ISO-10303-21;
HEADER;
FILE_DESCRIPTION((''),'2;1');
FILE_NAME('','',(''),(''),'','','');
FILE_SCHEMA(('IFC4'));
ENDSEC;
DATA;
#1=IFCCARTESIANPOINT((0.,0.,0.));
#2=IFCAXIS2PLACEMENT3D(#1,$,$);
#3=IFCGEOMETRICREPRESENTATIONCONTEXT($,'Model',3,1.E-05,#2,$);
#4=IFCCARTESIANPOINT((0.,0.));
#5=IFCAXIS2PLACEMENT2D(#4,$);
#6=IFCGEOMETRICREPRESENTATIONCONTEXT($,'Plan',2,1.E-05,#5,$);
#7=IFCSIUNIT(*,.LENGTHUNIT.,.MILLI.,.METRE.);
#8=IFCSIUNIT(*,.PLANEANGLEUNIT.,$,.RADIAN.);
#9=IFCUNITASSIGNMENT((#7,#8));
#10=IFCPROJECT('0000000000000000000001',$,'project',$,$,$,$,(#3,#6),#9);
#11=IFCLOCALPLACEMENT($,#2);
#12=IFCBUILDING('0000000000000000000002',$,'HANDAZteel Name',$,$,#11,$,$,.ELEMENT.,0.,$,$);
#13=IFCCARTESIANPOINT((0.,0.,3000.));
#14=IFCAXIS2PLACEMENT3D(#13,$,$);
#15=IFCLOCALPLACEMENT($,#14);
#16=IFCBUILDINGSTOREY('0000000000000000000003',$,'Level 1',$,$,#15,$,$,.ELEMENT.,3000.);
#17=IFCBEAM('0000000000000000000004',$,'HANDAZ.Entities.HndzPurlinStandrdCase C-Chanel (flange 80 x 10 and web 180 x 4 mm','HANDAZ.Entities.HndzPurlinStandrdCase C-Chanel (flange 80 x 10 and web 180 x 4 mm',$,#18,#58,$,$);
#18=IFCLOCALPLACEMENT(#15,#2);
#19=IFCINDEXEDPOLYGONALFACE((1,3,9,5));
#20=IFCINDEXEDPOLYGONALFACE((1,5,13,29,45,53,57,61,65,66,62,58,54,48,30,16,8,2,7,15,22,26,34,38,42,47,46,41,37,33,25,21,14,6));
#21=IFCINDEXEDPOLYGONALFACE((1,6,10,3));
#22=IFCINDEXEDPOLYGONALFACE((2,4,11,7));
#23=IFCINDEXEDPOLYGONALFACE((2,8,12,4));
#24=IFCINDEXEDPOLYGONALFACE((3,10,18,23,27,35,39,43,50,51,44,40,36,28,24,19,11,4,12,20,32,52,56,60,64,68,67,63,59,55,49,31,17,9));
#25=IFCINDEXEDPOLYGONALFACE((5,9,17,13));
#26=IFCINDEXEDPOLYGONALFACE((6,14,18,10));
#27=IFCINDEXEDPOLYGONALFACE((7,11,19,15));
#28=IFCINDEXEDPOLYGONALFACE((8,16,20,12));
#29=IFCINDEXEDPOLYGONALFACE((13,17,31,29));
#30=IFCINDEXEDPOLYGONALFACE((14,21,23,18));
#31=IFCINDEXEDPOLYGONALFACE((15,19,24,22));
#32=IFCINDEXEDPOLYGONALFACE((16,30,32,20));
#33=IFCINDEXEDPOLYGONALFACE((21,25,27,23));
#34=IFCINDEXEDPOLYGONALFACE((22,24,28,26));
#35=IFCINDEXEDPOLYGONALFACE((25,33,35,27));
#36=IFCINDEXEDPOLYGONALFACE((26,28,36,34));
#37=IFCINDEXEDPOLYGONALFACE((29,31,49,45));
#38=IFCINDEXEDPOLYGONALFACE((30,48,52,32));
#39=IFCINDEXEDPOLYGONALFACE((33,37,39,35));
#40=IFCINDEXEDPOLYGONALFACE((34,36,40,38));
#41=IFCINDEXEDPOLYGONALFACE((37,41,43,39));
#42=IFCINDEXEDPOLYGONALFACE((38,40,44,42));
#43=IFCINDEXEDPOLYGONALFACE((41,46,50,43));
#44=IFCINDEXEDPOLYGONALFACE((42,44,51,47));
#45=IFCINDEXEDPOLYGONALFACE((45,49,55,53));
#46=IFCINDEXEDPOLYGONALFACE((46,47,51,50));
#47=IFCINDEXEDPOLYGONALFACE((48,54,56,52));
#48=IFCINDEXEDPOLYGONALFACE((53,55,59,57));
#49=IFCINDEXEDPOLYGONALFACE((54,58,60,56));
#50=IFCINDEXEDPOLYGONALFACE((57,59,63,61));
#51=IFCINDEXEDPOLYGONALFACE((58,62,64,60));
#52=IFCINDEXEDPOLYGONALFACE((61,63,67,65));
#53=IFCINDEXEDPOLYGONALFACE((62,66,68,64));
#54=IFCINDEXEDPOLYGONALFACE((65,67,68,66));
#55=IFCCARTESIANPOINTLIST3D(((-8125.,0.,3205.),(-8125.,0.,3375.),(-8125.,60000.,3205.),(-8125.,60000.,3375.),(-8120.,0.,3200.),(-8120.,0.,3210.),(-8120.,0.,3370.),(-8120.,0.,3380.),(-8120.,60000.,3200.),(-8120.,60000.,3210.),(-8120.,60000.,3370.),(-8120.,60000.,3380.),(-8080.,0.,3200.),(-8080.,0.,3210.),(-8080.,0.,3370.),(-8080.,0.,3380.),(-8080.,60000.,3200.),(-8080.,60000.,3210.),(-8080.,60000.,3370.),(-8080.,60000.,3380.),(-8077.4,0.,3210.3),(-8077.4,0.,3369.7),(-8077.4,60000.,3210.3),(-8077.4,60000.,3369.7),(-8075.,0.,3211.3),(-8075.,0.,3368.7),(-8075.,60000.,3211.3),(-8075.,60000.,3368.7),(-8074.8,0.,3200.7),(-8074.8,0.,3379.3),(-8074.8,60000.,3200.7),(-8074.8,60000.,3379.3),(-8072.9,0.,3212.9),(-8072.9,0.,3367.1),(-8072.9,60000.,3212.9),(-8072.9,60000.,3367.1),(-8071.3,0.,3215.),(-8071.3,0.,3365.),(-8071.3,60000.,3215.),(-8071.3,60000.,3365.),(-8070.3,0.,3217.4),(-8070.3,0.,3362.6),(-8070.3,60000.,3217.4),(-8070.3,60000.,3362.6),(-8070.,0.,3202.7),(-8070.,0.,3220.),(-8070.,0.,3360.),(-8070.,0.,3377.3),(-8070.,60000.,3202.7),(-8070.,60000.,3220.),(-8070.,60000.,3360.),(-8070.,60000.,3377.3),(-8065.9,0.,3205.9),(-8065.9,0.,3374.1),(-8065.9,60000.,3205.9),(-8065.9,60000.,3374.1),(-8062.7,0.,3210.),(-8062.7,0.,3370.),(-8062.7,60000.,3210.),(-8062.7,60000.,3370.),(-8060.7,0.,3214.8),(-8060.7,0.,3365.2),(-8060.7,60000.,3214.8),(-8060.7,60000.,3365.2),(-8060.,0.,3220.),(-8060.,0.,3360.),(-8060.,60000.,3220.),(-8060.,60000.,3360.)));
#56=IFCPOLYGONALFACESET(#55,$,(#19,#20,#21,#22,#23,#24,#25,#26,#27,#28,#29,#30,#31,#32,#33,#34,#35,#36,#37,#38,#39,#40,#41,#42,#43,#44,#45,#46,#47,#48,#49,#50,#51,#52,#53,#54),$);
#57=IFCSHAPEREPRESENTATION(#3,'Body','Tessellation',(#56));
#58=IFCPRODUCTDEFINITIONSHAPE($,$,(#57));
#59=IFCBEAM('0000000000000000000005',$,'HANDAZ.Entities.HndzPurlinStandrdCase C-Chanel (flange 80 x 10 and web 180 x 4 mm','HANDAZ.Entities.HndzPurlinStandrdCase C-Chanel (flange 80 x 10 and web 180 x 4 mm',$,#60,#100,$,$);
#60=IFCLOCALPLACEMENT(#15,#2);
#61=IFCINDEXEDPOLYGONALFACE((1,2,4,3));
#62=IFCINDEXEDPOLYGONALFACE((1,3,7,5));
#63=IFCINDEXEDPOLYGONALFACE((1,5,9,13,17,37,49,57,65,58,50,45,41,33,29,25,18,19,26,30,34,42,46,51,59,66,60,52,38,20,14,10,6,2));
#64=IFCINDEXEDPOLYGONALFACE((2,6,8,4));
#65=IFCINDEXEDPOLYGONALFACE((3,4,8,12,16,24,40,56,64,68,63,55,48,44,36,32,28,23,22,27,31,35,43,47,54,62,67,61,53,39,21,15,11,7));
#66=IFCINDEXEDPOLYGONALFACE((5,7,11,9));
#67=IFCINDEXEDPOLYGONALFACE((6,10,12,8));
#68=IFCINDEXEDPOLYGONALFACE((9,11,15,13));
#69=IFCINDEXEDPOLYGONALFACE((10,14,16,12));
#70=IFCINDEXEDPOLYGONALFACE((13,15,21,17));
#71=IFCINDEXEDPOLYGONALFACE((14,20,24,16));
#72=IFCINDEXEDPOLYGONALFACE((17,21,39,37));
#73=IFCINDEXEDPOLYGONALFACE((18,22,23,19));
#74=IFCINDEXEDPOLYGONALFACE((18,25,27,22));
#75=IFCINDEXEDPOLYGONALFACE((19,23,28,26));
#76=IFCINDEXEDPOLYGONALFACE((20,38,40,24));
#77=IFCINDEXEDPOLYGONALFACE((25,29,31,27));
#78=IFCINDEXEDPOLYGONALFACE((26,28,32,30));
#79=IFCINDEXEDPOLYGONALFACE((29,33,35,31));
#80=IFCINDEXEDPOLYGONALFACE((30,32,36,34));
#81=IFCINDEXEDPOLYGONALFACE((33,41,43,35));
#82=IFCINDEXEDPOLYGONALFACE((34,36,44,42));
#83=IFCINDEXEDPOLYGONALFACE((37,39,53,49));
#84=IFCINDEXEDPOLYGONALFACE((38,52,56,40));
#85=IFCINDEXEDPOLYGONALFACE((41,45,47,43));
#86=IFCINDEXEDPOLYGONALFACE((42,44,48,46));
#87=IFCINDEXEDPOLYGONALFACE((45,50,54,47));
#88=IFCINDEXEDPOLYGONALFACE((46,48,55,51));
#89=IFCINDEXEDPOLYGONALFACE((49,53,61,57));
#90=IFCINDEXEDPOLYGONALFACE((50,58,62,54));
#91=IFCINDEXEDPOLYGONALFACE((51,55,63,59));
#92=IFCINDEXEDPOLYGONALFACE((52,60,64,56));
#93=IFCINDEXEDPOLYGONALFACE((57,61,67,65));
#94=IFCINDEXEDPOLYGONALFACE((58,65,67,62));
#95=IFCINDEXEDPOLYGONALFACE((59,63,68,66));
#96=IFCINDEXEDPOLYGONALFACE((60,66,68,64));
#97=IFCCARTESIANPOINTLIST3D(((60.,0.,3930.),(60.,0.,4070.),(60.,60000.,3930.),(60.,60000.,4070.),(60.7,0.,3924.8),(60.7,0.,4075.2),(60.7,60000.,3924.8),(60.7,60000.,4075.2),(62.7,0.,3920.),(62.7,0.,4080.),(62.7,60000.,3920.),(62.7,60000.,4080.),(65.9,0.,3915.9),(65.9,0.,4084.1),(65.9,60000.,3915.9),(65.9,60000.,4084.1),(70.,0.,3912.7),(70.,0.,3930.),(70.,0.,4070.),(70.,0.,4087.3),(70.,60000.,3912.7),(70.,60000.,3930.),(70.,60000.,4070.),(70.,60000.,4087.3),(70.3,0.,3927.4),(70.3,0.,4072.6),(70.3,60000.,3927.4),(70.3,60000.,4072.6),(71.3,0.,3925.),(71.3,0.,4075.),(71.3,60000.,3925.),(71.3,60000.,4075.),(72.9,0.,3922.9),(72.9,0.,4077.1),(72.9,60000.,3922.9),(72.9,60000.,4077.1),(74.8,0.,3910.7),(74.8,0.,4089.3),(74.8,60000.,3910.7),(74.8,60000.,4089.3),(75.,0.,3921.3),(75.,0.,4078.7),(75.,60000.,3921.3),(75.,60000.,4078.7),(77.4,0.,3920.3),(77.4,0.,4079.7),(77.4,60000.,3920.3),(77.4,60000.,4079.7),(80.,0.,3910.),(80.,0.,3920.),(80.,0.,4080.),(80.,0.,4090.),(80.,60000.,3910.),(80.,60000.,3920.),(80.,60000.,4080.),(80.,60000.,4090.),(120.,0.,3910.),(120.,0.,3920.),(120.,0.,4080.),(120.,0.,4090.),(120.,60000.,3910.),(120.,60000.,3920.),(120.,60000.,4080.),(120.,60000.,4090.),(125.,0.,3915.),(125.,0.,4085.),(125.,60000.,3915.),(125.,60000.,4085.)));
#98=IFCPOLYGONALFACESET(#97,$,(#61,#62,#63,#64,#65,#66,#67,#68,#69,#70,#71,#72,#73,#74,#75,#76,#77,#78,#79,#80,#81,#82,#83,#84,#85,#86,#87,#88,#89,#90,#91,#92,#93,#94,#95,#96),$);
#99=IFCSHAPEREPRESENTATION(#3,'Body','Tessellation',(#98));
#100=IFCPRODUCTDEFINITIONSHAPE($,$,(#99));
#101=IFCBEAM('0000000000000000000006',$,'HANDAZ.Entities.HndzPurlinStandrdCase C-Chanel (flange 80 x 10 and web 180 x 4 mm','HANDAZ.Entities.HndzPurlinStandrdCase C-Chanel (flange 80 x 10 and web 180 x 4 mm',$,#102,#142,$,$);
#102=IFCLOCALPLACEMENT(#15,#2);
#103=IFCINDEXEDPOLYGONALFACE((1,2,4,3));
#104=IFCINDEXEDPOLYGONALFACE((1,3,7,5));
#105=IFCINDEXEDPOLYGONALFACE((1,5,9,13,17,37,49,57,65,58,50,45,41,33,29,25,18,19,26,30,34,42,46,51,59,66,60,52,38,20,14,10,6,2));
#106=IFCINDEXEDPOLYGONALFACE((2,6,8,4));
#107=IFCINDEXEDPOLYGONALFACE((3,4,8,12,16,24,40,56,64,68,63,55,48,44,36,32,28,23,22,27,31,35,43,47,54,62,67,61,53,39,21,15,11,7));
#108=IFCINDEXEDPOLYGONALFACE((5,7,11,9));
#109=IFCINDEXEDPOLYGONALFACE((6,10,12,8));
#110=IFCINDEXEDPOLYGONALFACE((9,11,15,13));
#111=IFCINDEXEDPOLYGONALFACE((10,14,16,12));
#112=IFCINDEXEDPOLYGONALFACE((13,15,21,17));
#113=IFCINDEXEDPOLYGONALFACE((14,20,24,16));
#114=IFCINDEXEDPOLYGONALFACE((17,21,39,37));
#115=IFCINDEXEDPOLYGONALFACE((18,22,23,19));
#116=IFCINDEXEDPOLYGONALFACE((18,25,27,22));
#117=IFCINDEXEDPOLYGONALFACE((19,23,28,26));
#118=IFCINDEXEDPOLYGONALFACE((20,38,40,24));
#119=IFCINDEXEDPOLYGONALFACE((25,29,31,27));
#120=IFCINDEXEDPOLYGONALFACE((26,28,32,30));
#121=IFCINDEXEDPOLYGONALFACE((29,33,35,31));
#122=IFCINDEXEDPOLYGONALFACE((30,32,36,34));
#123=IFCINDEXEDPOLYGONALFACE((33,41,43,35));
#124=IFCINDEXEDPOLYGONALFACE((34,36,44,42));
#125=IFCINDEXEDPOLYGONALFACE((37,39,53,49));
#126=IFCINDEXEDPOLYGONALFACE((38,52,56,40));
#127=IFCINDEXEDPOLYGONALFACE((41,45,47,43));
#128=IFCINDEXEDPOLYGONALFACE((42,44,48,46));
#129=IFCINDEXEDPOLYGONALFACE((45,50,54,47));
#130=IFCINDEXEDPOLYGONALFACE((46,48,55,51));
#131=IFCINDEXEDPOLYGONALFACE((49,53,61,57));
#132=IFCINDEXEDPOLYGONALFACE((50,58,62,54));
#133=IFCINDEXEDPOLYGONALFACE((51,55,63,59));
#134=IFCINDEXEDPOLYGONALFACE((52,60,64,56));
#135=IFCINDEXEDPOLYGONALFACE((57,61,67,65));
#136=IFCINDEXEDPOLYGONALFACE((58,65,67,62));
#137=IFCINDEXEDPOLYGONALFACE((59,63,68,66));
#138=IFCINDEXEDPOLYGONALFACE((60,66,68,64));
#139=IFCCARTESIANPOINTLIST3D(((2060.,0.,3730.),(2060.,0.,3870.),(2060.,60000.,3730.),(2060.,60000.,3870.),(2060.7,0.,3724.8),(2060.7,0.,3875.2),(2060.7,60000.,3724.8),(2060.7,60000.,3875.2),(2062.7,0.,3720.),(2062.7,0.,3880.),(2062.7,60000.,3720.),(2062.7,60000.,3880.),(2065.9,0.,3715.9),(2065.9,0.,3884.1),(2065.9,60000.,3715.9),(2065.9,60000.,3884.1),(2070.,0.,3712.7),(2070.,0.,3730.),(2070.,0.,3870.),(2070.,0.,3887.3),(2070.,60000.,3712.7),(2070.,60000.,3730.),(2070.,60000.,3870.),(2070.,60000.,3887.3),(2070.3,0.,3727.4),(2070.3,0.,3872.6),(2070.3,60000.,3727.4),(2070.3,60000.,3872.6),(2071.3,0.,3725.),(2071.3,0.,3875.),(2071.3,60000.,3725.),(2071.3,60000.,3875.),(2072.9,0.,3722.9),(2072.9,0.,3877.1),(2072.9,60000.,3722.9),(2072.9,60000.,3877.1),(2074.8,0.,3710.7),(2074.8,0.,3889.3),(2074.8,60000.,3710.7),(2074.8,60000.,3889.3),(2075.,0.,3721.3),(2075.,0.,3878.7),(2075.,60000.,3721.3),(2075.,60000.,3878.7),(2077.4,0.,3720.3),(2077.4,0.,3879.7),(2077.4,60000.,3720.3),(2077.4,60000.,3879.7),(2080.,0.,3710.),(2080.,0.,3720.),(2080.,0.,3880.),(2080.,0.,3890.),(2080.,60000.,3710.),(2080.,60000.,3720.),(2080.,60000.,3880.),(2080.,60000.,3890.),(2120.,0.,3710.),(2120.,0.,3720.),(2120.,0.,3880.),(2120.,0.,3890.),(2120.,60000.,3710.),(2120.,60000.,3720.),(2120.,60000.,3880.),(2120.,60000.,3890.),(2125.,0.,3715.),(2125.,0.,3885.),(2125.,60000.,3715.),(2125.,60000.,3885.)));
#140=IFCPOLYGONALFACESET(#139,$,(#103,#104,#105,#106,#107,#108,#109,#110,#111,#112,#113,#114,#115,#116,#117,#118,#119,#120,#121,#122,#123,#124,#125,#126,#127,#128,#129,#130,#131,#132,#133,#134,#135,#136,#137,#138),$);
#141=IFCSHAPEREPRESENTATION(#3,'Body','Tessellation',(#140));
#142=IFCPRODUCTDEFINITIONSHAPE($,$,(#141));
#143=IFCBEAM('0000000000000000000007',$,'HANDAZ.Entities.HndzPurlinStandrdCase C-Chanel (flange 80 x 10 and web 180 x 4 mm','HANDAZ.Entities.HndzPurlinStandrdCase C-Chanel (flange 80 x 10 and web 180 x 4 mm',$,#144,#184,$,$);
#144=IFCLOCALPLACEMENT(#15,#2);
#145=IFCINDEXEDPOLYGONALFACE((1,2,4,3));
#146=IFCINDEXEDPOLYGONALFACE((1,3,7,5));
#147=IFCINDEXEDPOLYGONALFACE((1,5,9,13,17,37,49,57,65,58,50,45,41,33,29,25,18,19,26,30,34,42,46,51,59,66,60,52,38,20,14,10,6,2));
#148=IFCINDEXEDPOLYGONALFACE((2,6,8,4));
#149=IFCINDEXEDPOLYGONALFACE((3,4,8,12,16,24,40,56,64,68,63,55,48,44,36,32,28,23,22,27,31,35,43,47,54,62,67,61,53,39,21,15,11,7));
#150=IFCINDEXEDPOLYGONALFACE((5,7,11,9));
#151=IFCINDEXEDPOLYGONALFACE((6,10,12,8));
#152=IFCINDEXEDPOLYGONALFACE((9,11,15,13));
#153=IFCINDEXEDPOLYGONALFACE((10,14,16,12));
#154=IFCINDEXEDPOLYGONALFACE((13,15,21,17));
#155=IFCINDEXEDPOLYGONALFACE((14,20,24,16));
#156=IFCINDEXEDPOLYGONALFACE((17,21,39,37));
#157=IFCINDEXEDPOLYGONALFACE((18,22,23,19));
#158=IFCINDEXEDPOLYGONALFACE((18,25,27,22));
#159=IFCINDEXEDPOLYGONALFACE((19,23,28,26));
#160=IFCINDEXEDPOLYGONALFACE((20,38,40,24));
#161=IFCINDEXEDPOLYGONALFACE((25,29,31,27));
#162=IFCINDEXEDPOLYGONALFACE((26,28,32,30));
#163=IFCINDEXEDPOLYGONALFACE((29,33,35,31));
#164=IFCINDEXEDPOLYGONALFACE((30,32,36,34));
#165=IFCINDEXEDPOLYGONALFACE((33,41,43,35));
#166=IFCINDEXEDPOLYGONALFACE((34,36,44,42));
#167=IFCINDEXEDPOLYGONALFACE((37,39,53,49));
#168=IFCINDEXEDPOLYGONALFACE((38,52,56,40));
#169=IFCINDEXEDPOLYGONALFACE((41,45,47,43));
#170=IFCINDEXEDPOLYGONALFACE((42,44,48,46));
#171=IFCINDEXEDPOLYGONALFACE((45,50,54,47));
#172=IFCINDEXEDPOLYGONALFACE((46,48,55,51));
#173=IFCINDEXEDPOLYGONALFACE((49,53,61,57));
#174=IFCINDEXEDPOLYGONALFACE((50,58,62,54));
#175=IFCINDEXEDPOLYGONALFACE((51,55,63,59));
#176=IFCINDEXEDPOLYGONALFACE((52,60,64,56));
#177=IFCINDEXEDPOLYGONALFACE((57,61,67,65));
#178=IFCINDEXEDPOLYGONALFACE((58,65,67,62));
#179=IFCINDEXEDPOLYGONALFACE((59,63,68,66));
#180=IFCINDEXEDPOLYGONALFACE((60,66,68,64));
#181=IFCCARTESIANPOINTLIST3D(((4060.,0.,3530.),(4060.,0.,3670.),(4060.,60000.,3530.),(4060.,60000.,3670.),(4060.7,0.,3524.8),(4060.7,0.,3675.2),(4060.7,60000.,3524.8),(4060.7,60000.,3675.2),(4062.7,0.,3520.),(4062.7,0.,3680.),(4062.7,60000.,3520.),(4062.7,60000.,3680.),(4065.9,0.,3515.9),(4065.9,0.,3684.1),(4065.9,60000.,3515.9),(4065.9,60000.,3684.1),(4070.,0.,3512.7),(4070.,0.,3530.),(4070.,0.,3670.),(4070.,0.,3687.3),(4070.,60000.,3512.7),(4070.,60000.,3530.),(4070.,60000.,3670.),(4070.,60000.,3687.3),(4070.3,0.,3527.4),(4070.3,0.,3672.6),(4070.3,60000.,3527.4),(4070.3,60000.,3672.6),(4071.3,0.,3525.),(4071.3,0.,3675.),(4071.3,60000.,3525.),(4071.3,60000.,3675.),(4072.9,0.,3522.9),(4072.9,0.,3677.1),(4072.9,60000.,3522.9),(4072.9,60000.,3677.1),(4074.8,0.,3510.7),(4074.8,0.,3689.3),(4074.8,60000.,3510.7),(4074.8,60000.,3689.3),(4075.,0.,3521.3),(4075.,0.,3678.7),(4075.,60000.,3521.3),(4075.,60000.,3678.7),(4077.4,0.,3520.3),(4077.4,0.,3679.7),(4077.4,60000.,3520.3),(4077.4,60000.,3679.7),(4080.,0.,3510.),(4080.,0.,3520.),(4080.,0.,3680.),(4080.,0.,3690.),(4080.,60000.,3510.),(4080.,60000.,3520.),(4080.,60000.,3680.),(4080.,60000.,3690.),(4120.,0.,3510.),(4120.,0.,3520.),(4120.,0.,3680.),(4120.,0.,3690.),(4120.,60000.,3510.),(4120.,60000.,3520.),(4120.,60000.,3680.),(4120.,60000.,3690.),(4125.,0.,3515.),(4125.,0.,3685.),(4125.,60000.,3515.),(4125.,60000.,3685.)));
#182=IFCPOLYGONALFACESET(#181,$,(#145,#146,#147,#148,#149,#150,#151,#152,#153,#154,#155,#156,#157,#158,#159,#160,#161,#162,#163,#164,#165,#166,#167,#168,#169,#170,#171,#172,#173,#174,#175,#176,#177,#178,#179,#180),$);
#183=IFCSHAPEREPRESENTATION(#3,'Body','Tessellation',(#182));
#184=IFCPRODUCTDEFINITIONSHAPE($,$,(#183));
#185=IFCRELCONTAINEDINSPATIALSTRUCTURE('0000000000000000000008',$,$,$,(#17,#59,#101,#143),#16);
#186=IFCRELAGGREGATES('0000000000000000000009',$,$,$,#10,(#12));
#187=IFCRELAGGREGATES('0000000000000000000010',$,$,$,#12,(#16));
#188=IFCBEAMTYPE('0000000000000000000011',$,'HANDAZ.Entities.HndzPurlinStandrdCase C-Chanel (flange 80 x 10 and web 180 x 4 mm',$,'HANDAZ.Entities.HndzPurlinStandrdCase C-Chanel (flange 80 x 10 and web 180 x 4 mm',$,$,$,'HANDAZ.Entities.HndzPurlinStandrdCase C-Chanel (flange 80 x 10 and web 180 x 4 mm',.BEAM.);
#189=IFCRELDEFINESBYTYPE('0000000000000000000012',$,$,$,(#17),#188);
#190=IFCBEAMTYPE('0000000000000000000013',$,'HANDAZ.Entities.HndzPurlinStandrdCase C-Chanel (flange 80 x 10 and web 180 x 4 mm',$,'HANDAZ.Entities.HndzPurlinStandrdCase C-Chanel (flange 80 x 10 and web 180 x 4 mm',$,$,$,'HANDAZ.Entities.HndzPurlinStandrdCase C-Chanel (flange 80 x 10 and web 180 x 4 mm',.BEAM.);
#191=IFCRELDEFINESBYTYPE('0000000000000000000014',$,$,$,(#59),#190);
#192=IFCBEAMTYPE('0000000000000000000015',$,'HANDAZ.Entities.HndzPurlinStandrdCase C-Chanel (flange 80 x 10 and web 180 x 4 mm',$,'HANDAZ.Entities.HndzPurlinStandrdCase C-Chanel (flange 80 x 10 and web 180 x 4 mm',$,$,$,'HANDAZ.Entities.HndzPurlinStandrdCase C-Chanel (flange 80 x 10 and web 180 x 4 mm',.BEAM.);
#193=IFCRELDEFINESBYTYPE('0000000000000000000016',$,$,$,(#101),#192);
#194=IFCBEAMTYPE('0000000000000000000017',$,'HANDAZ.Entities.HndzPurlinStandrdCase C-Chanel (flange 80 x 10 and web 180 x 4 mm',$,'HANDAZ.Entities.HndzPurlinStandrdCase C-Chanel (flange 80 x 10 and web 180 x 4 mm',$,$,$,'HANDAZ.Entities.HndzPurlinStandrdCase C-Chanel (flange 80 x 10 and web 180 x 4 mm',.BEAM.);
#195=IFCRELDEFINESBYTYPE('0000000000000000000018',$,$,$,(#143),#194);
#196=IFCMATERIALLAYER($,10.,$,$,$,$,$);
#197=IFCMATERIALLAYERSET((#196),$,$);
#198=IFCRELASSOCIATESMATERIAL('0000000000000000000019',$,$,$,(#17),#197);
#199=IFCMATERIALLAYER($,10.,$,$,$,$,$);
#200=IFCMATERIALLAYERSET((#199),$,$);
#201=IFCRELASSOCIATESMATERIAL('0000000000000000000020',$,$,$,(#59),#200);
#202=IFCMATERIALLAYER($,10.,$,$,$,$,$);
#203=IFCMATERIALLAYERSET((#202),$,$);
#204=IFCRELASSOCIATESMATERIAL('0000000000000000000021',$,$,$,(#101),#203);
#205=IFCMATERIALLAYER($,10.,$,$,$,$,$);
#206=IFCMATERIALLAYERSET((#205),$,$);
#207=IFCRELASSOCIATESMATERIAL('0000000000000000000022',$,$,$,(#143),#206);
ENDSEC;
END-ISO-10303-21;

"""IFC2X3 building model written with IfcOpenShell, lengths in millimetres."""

from ifc_helpers import new_model, si_unit, frame, frame_2d, origin, origin_2d, place, context, project, spatial, c_section, extrude, layer, layer_set, layer_usage, type_object, element, save


model = new_model("IFC2X3")

# Units and contexts
model_context = context("Model", 3, precision=1e-05, world=origin())
plan_context = context("Plan", 2, precision=1e-05, world=origin_2d())
ifc_project = project(units=[si_unit("LENGTHUNIT", "METRE", prefix="MILLI"), si_unit("PLANEANGLEUNIT", "RADIAN")], contexts=[model_context, plan_context])

# Building, storey
building_placement = place(None, origin())
building = spatial("IfcBuilding", under=ifc_project, at=building_placement, Name="HANDAZteel Name", CompositionType="ELEMENT", ElevationOfRefHeight=0.0)
storey_placement = place(None, frame((0.0, 0.0, 3000.0)))
storey = spatial("IfcBuildingStorey", under=building, at=storey_placement, Name="Level 1", CompositionType="ELEMENT", Elevation=3000.0)

# Beams
ifc_layer_1 = layer(None, 10.0)
ifc_layer_set_1 = layer_set([ifc_layer_1])
ifc_layer_usage_1 = layer_usage(ifc_layer_set_1, "AXIS2", "NEGATIVE", 150.0)
beam_type_1 = type_object("IfcBeamType", Name="HANDAZ.Entities.HndzPurlinStandrdCase C-Chanel (flange 80 x 10 and web 180 x 4 mm", ApplicableOccurrence="HANDAZ.Entities.HndzPurlinStandrdCase C-Chanel (flange 80 x 10 and web 180 x 4 mm", ElementType="HANDAZ.Entities.HndzPurlinStandrdCase C-Chanel (flange 80 x 10 and web 180 x 4 mm", PredefinedType="BEAM")
beam_1_placement = place(None, frame((-8100.0, 0.0, 6290.0), z_axis=(0.0, 1.0, 0.0), x_axis=(0.0, 0.0, 1.0)))
element("IfcBeam", 1, at=beam_1_placement, inside=storey, type_object=beam_type_1, material=ifc_layer_usage_1, Name="HANDAZ.Entities.HndzPurlinStandrdCase C-Chanel (flange 80 x 10 and web 180 x 4 mm", Description="HANDAZ.Entities.HndzPurlinStandrdCase C-Chanel (flange 80 x 10 and web 180 x 4 mm", context=model_context, shape_type="SweptSolid", body=[
    extrude(c_section(Depth=180.0, Width=80.0, WallThickness=10.0, Girth=5.0, InternalFilletRadius=10.0, at=frame_2d((0.0, 0.0), x_axis=(0.0, -1.0))), origin(), (0.0, 0.0, 1.0), 60000.0),
])
ifc_layer_2 = layer(None, 10.0)
ifc_layer_set_2 = layer_set([ifc_layer_2])
ifc_layer_usage_2 = layer_usage(ifc_layer_set_2, "AXIS2", "NEGATIVE", 150.0)
beam_type_2 = type_object("IfcBeamType", Name="HANDAZ.Entities.HndzPurlinStandrdCase C-Chanel (flange 80 x 10 and web 180 x 4 mm", ApplicableOccurrence="HANDAZ.Entities.HndzPurlinStandrdCase C-Chanel (flange 80 x 10 and web 180 x 4 mm", ElementType="HANDAZ.Entities.HndzPurlinStandrdCase C-Chanel (flange 80 x 10 and web 180 x 4 mm", PredefinedType="BEAM")
beam_2_placement = place(None, frame((100.0, 0.0, 7000.0), z_axis=(0.0, 1.0, 0.0), x_axis=(0.0, 0.0, 1.0)))
element("IfcBeam", 2, at=beam_2_placement, inside=storey, type_object=beam_type_2, material=ifc_layer_usage_2, Name="HANDAZ.Entities.HndzPurlinStandrdCase C-Chanel (flange 80 x 10 and web 180 x 4 mm", Description="HANDAZ.Entities.HndzPurlinStandrdCase C-Chanel (flange 80 x 10 and web 180 x 4 mm", context=model_context, shape_type="SweptSolid", body=[
    extrude(c_section(Depth=180.0, Width=80.0, WallThickness=10.0, Girth=5.0, InternalFilletRadius=10.0, at=frame_2d((0.0, 0.0), x_axis=(0.0, 1.0))), origin(), (0.0, 0.0, 1.0), 60000.0),
])
ifc_layer_3 = layer(None, 10.0)
ifc_layer_set_3 = layer_set([ifc_layer_3])
ifc_layer_usage_3 = layer_usage(ifc_layer_set_3, "AXIS2", "NEGATIVE", 150.0)
beam_type_3 = type_object("IfcBeamType", Name="HANDAZ.Entities.HndzPurlinStandrdCase C-Chanel (flange 80 x 10 and web 180 x 4 mm", ApplicableOccurrence="HANDAZ.Entities.HndzPurlinStandrdCase C-Chanel (flange 80 x 10 and web 180 x 4 mm", ElementType="HANDAZ.Entities.HndzPurlinStandrdCase C-Chanel (flange 80 x 10 and web 180 x 4 mm", PredefinedType="BEAM")
beam_3_placement = place(None, frame((2100.0, 0.0, 6800.0), z_axis=(0.0, 1.0, 0.0), x_axis=(0.0, 0.0, 1.0)))
element("IfcBeam", 3, at=beam_3_placement, inside=storey, type_object=beam_type_3, material=ifc_layer_usage_3, Name="HANDAZ.Entities.HndzPurlinStandrdCase C-Chanel (flange 80 x 10 and web 180 x 4 mm", Description="HANDAZ.Entities.HndzPurlinStandrdCase C-Chanel (flange 80 x 10 and web 180 x 4 mm", context=model_context, shape_type="SweptSolid", body=[
    extrude(c_section(Depth=180.0, Width=80.0, WallThickness=10.0, Girth=5.0, InternalFilletRadius=10.0, at=frame_2d((0.0, 0.0), x_axis=(0.0, 1.0))), origin(), (0.0, 0.0, 1.0), 60000.0),
])
ifc_layer_4 = layer(None, 10.0)
ifc_layer_set_4 = layer_set([ifc_layer_4])
ifc_layer_usage_4 = layer_usage(ifc_layer_set_4, "AXIS2", "NEGATIVE", 150.0)
beam_type_4 = type_object("IfcBeamType", Name="HANDAZ.Entities.HndzPurlinStandrdCase C-Chanel (flange 80 x 10 and web 180 x 4 mm", ApplicableOccurrence="HANDAZ.Entities.HndzPurlinStandrdCase C-Chanel (flange 80 x 10 and web 180 x 4 mm", ElementType="HANDAZ.Entities.HndzPurlinStandrdCase C-Chanel (flange 80 x 10 and web 180 x 4 mm", PredefinedType="BEAM")
beam_4_placement = place(None, frame((4100.0, 0.0, 6600.0), z_axis=(0.0, 1.0, 0.0), x_axis=(0.0, 0.0, 1.0)))
element("IfcBeam", 4, at=beam_4_placement, inside=storey, type_object=beam_type_4, material=ifc_layer_usage_4, Name="HANDAZ.Entities.HndzPurlinStandrdCase C-Chanel (flange 80 x 10 and web 180 x 4 mm", Description="HANDAZ.Entities.HndzPurlinStandrdCase C-Chanel (flange 80 x 10 and web 180 x 4 mm", context=model_context, shape_type="SweptSolid", body=[
    extrude(c_section(Depth=180.0, Width=80.0, WallThickness=10.0, Girth=5.0, InternalFilletRadius=10.0, at=frame_2d((0.0, 0.0), x_axis=(0.0, 1.0))), origin(), (0.0, 0.0, 1.0), 60000.0),
])

save(model, "model.ifc")
